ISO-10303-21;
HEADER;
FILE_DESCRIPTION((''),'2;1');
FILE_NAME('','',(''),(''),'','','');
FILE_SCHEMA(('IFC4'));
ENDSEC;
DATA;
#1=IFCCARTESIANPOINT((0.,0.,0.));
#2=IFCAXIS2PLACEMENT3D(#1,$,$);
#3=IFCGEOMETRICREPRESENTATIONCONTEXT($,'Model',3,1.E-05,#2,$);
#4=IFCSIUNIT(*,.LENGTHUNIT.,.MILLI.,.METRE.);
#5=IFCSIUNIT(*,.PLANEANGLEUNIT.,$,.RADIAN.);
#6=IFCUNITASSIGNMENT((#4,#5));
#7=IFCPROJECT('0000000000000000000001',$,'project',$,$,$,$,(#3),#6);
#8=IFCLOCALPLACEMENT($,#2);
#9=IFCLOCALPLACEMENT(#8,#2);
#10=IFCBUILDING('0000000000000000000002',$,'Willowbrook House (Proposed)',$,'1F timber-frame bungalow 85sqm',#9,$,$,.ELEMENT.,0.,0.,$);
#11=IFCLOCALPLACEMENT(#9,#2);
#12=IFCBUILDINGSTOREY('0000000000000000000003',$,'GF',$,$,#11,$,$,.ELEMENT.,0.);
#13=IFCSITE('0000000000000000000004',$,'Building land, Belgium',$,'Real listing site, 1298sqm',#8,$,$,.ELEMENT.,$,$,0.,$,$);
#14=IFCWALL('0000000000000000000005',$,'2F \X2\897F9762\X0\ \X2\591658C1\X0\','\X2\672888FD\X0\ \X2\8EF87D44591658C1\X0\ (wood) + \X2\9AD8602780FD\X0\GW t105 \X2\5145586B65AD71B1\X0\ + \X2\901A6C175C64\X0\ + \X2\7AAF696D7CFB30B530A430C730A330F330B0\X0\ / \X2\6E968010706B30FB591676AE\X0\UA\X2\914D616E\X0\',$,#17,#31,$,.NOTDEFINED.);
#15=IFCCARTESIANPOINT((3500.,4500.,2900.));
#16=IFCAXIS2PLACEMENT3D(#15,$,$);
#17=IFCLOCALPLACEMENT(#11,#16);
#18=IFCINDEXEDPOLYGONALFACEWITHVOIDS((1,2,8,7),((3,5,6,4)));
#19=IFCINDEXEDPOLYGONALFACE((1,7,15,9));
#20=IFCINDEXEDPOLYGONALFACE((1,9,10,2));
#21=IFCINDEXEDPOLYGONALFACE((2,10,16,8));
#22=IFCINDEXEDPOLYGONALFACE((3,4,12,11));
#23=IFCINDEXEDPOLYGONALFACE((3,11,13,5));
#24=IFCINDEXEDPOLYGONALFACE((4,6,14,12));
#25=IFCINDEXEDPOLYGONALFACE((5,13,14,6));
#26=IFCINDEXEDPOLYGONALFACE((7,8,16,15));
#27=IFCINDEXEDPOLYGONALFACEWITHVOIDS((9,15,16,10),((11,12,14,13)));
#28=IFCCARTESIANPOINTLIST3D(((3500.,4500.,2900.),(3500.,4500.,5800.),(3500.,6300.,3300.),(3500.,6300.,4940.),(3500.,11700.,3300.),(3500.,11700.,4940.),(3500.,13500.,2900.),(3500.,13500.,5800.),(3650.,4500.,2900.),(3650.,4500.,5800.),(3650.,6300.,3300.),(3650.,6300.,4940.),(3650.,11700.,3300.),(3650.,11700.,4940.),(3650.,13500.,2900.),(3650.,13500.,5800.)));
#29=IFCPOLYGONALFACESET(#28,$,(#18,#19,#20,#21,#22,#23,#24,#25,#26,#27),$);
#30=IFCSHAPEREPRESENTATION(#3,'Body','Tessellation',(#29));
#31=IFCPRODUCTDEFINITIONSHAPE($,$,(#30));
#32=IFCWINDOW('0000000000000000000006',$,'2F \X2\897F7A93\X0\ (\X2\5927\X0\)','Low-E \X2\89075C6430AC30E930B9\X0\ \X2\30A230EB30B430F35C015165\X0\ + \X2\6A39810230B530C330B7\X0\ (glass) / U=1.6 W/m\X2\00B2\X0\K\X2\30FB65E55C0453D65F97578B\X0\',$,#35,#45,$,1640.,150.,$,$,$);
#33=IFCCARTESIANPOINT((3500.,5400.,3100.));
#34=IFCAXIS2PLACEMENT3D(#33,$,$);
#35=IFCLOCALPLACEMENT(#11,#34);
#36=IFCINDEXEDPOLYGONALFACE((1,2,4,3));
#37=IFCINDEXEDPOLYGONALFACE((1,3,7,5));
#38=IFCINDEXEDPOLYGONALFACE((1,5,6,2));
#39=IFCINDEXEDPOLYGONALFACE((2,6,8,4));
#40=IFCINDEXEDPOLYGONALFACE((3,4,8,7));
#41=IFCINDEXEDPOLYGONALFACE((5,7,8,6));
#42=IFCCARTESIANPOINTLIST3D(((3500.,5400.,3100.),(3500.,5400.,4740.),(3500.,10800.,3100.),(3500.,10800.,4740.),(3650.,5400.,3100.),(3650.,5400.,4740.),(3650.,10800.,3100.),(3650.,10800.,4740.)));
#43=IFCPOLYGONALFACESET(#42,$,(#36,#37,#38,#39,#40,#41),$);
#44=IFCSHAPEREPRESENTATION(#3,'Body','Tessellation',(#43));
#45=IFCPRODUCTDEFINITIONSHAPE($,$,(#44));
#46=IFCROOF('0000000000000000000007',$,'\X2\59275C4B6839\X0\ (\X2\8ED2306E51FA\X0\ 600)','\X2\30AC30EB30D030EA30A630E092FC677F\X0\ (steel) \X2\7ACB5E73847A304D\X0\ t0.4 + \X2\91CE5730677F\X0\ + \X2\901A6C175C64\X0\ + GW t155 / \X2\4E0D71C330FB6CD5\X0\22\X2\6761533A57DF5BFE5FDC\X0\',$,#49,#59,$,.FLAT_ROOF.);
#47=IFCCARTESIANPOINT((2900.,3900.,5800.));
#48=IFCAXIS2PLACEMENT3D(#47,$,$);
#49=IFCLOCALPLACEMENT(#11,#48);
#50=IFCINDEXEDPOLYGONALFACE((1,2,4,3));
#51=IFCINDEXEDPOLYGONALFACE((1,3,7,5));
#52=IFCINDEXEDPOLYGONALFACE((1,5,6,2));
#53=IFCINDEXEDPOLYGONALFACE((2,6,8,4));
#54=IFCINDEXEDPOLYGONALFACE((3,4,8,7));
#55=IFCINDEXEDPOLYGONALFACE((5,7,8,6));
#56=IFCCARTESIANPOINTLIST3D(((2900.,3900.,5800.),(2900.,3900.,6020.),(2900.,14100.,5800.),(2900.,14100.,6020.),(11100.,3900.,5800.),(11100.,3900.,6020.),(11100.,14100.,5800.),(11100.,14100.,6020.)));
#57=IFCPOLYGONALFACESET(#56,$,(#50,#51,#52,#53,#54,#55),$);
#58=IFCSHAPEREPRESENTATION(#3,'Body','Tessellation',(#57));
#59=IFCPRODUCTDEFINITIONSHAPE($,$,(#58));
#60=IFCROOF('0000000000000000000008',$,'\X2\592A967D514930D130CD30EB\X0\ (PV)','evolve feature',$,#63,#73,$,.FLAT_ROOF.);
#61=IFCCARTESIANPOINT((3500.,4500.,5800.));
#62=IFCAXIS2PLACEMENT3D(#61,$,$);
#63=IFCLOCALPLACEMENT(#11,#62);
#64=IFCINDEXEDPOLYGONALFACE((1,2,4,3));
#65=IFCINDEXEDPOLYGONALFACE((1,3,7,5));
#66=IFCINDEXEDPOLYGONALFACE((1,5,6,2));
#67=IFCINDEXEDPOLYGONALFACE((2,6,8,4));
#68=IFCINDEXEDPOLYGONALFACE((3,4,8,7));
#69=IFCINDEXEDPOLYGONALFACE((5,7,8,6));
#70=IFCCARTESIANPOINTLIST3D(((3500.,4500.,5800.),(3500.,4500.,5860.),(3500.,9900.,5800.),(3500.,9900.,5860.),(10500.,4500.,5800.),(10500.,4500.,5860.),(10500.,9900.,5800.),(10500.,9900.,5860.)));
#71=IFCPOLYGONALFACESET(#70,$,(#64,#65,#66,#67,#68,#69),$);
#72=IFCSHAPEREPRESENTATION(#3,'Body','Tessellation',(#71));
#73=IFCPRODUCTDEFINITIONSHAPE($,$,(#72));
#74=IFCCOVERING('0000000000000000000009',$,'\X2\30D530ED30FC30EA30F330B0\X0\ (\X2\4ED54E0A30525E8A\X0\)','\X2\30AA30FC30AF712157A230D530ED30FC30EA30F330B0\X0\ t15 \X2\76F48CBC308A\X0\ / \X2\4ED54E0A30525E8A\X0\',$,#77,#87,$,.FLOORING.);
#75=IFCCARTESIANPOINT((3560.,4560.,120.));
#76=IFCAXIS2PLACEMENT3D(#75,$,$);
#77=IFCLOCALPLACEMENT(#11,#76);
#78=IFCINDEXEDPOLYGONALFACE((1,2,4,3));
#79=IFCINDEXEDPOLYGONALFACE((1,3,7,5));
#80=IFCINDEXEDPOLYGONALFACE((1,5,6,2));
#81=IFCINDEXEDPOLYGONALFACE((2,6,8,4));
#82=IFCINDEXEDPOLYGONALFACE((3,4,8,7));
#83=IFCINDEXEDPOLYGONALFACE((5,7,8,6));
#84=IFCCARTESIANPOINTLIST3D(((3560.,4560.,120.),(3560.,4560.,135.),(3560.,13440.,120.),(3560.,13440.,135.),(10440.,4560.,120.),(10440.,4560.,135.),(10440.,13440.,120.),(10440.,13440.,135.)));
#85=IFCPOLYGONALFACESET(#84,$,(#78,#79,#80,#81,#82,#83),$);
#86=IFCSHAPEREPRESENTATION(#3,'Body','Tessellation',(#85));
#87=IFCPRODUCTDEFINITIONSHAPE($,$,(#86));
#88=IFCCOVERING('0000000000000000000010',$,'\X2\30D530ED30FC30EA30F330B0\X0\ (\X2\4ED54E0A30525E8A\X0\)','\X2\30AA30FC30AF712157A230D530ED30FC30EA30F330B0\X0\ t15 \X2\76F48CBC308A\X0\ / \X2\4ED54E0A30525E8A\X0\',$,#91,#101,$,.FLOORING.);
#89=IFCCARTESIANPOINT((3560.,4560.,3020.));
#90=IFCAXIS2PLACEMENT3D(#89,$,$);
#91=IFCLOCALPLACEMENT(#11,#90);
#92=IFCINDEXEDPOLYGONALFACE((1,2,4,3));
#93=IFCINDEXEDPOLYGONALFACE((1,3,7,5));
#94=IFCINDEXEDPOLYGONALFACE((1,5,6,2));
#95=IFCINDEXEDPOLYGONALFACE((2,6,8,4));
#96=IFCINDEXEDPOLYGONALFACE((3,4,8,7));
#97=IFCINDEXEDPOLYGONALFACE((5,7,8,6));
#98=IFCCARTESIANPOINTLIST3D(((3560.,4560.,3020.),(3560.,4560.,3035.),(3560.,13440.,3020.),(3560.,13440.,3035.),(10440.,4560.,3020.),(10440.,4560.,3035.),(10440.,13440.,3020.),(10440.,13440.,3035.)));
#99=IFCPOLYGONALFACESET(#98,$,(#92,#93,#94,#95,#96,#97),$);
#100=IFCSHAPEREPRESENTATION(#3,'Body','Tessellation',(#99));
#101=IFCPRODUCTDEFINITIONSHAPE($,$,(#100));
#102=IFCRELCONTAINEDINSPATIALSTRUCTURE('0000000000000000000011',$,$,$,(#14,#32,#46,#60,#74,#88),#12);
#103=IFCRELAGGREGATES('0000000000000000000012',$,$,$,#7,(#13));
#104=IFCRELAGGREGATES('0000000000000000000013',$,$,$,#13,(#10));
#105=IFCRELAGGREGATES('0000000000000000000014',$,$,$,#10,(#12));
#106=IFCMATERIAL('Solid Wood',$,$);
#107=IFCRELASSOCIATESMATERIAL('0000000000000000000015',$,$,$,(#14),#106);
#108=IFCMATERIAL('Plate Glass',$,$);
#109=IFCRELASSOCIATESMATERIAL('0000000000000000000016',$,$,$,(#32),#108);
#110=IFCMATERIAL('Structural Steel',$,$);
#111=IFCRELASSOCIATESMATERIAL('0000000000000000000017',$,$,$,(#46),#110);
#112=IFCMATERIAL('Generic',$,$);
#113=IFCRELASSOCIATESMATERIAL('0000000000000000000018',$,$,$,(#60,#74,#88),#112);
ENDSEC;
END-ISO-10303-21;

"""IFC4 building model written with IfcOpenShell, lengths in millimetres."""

from ifc_helpers import new_model, si_unit, frame, frame_2d, origin, place, context, project, spatial, rectangle, extrude, material, element, fill, save


model = new_model("IFC4")

# Units and contexts
model_context = context("Model", 3, precision=1e-05, world=origin())
ifc_project = project(units=[si_unit("LENGTHUNIT", "METRE", prefix="MILLI"), si_unit("PLANEANGLEUNIT", "RADIAN")], contexts=[model_context])

# Site, building, storey
site_placement = place(None, origin())
site = spatial("IfcSite", under=ifc_project, at=site_placement, Name="Building land, Belgium", ObjectType="Real listing site, 1298sqm", CompositionType="ELEMENT", RefElevation=0.0)
building_placement = place(site_placement, origin())
building = spatial("IfcBuilding", under=site, at=building_placement, Name="Willowbrook House (Proposed)", ObjectType="1F timber-frame bungalow 85sqm", CompositionType="ELEMENT", ElevationOfRefHeight=0.0, ElevationOfTerrain=0.0)
storey_placement = place(building_placement, origin())
storey = spatial("IfcBuildingStorey", under=building, at=storey_placement, Name="GF", CompositionType="ELEMENT", Elevation=0.0)

# Shared definitions
ifc_material_1 = material(Name="Solid Wood")
ifc_material_2 = material(Name="Generic")

# Shared definitions
ifc_material_3 = material(Name="Plate Glass")

# Wall, opening, window
wall_1_placement = place(storey_placement, frame((3500.0, 4500.0, 2900.0)))
wall_1 = element("IfcWall", 1, at=wall_1_placement, inside=storey, material=ifc_material_1, Name="2F 西面 外壁", Description="木製 軸組外壁 (wood) + 高性能GW t105 充填断熱 + 通気層 + 窯業系サイディング / 準耐火・外皮UA配慮", PredefinedType="NOTDEFINED", context=model_context, shape_type="SweptSolid", body=[
    extrude(rectangle(XDim=150.0, YDim=9000.0, at=frame_2d((75.0, 4500.0))), frame((3500.0, 4500.0, 2900.0)), (0.0, 0.0, 1.0), 2900.0),
])
opening_1_placement = place(storey_placement, frame((3500.0, 5400.0, 3100.0)))
opening_1 = element("IfcOpeningElement", 2, at=opening_1_placement, cuts=wall_1, PredefinedType="NOTDEFINED", context=model_context, shape_type="SweptSolid", body=[
    extrude(rectangle(XDim=150.0, YDim=5400.0, at=frame_2d((75.0, 2700.0))), frame((3500.0, 5400.0, 3100.0)), (0.0, 0.0, 1.0), 1640.0),
])
window_1_placement = place(storey_placement, frame((3500.0, 5400.0, 3100.0)))
window_1 = element("IfcWindow", 3, at=window_1_placement, inside=storey, material=ifc_material_3, Name="2F 西窓 (大)", Description="Low-E 複層ガラス アルゴン封入 + 樹脂サッシ (glass) / U=1.6 W/m²K・日射取得型", OverallHeight=1640.0, OverallWidth=150.0, context=model_context, shape_type="SweptSolid", body=[
    extrude(rectangle(XDim=150.0, YDim=5400.0, at=frame_2d((75.0, 2700.0))), frame((3500.0, 5400.0, 3100.0)), (0.0, 0.0, 1.0), 1640.0),
])
fill(opening_1, window_1)

# Roofs
ifc_material_4 = material(Name="Structural Steel")
roof_1_placement = place(storey_placement, frame((2900.0, 3900.0, 5800.0)))
element("IfcRoof", 4, at=roof_1_placement, inside=storey, material=ifc_material_4, Name="大屋根 (軒の出 600)", Description="ガルバリウム鋼板 (steel) 立平葺き t0.4 + 野地板 + 通気層 + GW t155 / 不燃・法22条区域対応", PredefinedType="FLAT_ROOF", context=model_context, shape_type="SweptSolid", body=[
    extrude(rectangle(XDim=8200.0, YDim=10200.0, at=frame_2d((4100.0, 5100.0))), frame((2900.0, 3900.0, 5800.0)), (0.0, 0.0, 1.0), 220.0),
])
roof_2_placement = place(storey_placement, frame((3500.0, 4500.0, 5800.0)))
element("IfcRoof", 5, at=roof_2_placement, inside=storey, material=ifc_material_2, Name="太陽光パネル (PV)", Description="evolve feature", PredefinedType="FLAT_ROOF", context=model_context, shape_type="SweptSolid", body=[
    extrude(rectangle(XDim=7000.0, YDim=5400.0, at=frame_2d((3500.0, 2700.0))), frame((3500.0, 4500.0, 5800.0)), (0.0, 0.0, 1.0), 60.0),
])

# Coverings
covering_1_placement = place(storey_placement, frame((3560.0, 4560.0, 120.0)))
element("IfcCovering", 6, at=covering_1_placement, inside=storey, material=ifc_material_2, Name="フローリング (仕上げ床)", Description="オーク無垢フローリング t15 直貼り / 仕上げ床", PredefinedType="FLOORING", context=model_context, shape_type="SweptSolid", body=[
    extrude(rectangle(XDim=6880.0, YDim=8880.0, at=frame_2d((3440.0, 4440.0))), frame((3560.0, 4560.0, 120.0)), (0.0, 0.0, 1.0), 15.0),
])
covering_2_placement = place(storey_placement, frame((3560.0, 4560.0, 3020.0)))
element("IfcCovering", 7, at=covering_2_placement, inside=storey, material=ifc_material_2, Name="フローリング (仕上げ床)", Description="オーク無垢フローリング t15 直貼り / 仕上げ床", PredefinedType="FLOORING", context=model_context, shape_type="SweptSolid", body=[
    extrude(rectangle(XDim=6880.0, YDim=8880.0, at=frame_2d((3440.0, 4440.0))), frame((3560.0, 4560.0, 3020.0)), (0.0, 0.0, 1.0), 15.0),
])

save(model, "model.ifc")
